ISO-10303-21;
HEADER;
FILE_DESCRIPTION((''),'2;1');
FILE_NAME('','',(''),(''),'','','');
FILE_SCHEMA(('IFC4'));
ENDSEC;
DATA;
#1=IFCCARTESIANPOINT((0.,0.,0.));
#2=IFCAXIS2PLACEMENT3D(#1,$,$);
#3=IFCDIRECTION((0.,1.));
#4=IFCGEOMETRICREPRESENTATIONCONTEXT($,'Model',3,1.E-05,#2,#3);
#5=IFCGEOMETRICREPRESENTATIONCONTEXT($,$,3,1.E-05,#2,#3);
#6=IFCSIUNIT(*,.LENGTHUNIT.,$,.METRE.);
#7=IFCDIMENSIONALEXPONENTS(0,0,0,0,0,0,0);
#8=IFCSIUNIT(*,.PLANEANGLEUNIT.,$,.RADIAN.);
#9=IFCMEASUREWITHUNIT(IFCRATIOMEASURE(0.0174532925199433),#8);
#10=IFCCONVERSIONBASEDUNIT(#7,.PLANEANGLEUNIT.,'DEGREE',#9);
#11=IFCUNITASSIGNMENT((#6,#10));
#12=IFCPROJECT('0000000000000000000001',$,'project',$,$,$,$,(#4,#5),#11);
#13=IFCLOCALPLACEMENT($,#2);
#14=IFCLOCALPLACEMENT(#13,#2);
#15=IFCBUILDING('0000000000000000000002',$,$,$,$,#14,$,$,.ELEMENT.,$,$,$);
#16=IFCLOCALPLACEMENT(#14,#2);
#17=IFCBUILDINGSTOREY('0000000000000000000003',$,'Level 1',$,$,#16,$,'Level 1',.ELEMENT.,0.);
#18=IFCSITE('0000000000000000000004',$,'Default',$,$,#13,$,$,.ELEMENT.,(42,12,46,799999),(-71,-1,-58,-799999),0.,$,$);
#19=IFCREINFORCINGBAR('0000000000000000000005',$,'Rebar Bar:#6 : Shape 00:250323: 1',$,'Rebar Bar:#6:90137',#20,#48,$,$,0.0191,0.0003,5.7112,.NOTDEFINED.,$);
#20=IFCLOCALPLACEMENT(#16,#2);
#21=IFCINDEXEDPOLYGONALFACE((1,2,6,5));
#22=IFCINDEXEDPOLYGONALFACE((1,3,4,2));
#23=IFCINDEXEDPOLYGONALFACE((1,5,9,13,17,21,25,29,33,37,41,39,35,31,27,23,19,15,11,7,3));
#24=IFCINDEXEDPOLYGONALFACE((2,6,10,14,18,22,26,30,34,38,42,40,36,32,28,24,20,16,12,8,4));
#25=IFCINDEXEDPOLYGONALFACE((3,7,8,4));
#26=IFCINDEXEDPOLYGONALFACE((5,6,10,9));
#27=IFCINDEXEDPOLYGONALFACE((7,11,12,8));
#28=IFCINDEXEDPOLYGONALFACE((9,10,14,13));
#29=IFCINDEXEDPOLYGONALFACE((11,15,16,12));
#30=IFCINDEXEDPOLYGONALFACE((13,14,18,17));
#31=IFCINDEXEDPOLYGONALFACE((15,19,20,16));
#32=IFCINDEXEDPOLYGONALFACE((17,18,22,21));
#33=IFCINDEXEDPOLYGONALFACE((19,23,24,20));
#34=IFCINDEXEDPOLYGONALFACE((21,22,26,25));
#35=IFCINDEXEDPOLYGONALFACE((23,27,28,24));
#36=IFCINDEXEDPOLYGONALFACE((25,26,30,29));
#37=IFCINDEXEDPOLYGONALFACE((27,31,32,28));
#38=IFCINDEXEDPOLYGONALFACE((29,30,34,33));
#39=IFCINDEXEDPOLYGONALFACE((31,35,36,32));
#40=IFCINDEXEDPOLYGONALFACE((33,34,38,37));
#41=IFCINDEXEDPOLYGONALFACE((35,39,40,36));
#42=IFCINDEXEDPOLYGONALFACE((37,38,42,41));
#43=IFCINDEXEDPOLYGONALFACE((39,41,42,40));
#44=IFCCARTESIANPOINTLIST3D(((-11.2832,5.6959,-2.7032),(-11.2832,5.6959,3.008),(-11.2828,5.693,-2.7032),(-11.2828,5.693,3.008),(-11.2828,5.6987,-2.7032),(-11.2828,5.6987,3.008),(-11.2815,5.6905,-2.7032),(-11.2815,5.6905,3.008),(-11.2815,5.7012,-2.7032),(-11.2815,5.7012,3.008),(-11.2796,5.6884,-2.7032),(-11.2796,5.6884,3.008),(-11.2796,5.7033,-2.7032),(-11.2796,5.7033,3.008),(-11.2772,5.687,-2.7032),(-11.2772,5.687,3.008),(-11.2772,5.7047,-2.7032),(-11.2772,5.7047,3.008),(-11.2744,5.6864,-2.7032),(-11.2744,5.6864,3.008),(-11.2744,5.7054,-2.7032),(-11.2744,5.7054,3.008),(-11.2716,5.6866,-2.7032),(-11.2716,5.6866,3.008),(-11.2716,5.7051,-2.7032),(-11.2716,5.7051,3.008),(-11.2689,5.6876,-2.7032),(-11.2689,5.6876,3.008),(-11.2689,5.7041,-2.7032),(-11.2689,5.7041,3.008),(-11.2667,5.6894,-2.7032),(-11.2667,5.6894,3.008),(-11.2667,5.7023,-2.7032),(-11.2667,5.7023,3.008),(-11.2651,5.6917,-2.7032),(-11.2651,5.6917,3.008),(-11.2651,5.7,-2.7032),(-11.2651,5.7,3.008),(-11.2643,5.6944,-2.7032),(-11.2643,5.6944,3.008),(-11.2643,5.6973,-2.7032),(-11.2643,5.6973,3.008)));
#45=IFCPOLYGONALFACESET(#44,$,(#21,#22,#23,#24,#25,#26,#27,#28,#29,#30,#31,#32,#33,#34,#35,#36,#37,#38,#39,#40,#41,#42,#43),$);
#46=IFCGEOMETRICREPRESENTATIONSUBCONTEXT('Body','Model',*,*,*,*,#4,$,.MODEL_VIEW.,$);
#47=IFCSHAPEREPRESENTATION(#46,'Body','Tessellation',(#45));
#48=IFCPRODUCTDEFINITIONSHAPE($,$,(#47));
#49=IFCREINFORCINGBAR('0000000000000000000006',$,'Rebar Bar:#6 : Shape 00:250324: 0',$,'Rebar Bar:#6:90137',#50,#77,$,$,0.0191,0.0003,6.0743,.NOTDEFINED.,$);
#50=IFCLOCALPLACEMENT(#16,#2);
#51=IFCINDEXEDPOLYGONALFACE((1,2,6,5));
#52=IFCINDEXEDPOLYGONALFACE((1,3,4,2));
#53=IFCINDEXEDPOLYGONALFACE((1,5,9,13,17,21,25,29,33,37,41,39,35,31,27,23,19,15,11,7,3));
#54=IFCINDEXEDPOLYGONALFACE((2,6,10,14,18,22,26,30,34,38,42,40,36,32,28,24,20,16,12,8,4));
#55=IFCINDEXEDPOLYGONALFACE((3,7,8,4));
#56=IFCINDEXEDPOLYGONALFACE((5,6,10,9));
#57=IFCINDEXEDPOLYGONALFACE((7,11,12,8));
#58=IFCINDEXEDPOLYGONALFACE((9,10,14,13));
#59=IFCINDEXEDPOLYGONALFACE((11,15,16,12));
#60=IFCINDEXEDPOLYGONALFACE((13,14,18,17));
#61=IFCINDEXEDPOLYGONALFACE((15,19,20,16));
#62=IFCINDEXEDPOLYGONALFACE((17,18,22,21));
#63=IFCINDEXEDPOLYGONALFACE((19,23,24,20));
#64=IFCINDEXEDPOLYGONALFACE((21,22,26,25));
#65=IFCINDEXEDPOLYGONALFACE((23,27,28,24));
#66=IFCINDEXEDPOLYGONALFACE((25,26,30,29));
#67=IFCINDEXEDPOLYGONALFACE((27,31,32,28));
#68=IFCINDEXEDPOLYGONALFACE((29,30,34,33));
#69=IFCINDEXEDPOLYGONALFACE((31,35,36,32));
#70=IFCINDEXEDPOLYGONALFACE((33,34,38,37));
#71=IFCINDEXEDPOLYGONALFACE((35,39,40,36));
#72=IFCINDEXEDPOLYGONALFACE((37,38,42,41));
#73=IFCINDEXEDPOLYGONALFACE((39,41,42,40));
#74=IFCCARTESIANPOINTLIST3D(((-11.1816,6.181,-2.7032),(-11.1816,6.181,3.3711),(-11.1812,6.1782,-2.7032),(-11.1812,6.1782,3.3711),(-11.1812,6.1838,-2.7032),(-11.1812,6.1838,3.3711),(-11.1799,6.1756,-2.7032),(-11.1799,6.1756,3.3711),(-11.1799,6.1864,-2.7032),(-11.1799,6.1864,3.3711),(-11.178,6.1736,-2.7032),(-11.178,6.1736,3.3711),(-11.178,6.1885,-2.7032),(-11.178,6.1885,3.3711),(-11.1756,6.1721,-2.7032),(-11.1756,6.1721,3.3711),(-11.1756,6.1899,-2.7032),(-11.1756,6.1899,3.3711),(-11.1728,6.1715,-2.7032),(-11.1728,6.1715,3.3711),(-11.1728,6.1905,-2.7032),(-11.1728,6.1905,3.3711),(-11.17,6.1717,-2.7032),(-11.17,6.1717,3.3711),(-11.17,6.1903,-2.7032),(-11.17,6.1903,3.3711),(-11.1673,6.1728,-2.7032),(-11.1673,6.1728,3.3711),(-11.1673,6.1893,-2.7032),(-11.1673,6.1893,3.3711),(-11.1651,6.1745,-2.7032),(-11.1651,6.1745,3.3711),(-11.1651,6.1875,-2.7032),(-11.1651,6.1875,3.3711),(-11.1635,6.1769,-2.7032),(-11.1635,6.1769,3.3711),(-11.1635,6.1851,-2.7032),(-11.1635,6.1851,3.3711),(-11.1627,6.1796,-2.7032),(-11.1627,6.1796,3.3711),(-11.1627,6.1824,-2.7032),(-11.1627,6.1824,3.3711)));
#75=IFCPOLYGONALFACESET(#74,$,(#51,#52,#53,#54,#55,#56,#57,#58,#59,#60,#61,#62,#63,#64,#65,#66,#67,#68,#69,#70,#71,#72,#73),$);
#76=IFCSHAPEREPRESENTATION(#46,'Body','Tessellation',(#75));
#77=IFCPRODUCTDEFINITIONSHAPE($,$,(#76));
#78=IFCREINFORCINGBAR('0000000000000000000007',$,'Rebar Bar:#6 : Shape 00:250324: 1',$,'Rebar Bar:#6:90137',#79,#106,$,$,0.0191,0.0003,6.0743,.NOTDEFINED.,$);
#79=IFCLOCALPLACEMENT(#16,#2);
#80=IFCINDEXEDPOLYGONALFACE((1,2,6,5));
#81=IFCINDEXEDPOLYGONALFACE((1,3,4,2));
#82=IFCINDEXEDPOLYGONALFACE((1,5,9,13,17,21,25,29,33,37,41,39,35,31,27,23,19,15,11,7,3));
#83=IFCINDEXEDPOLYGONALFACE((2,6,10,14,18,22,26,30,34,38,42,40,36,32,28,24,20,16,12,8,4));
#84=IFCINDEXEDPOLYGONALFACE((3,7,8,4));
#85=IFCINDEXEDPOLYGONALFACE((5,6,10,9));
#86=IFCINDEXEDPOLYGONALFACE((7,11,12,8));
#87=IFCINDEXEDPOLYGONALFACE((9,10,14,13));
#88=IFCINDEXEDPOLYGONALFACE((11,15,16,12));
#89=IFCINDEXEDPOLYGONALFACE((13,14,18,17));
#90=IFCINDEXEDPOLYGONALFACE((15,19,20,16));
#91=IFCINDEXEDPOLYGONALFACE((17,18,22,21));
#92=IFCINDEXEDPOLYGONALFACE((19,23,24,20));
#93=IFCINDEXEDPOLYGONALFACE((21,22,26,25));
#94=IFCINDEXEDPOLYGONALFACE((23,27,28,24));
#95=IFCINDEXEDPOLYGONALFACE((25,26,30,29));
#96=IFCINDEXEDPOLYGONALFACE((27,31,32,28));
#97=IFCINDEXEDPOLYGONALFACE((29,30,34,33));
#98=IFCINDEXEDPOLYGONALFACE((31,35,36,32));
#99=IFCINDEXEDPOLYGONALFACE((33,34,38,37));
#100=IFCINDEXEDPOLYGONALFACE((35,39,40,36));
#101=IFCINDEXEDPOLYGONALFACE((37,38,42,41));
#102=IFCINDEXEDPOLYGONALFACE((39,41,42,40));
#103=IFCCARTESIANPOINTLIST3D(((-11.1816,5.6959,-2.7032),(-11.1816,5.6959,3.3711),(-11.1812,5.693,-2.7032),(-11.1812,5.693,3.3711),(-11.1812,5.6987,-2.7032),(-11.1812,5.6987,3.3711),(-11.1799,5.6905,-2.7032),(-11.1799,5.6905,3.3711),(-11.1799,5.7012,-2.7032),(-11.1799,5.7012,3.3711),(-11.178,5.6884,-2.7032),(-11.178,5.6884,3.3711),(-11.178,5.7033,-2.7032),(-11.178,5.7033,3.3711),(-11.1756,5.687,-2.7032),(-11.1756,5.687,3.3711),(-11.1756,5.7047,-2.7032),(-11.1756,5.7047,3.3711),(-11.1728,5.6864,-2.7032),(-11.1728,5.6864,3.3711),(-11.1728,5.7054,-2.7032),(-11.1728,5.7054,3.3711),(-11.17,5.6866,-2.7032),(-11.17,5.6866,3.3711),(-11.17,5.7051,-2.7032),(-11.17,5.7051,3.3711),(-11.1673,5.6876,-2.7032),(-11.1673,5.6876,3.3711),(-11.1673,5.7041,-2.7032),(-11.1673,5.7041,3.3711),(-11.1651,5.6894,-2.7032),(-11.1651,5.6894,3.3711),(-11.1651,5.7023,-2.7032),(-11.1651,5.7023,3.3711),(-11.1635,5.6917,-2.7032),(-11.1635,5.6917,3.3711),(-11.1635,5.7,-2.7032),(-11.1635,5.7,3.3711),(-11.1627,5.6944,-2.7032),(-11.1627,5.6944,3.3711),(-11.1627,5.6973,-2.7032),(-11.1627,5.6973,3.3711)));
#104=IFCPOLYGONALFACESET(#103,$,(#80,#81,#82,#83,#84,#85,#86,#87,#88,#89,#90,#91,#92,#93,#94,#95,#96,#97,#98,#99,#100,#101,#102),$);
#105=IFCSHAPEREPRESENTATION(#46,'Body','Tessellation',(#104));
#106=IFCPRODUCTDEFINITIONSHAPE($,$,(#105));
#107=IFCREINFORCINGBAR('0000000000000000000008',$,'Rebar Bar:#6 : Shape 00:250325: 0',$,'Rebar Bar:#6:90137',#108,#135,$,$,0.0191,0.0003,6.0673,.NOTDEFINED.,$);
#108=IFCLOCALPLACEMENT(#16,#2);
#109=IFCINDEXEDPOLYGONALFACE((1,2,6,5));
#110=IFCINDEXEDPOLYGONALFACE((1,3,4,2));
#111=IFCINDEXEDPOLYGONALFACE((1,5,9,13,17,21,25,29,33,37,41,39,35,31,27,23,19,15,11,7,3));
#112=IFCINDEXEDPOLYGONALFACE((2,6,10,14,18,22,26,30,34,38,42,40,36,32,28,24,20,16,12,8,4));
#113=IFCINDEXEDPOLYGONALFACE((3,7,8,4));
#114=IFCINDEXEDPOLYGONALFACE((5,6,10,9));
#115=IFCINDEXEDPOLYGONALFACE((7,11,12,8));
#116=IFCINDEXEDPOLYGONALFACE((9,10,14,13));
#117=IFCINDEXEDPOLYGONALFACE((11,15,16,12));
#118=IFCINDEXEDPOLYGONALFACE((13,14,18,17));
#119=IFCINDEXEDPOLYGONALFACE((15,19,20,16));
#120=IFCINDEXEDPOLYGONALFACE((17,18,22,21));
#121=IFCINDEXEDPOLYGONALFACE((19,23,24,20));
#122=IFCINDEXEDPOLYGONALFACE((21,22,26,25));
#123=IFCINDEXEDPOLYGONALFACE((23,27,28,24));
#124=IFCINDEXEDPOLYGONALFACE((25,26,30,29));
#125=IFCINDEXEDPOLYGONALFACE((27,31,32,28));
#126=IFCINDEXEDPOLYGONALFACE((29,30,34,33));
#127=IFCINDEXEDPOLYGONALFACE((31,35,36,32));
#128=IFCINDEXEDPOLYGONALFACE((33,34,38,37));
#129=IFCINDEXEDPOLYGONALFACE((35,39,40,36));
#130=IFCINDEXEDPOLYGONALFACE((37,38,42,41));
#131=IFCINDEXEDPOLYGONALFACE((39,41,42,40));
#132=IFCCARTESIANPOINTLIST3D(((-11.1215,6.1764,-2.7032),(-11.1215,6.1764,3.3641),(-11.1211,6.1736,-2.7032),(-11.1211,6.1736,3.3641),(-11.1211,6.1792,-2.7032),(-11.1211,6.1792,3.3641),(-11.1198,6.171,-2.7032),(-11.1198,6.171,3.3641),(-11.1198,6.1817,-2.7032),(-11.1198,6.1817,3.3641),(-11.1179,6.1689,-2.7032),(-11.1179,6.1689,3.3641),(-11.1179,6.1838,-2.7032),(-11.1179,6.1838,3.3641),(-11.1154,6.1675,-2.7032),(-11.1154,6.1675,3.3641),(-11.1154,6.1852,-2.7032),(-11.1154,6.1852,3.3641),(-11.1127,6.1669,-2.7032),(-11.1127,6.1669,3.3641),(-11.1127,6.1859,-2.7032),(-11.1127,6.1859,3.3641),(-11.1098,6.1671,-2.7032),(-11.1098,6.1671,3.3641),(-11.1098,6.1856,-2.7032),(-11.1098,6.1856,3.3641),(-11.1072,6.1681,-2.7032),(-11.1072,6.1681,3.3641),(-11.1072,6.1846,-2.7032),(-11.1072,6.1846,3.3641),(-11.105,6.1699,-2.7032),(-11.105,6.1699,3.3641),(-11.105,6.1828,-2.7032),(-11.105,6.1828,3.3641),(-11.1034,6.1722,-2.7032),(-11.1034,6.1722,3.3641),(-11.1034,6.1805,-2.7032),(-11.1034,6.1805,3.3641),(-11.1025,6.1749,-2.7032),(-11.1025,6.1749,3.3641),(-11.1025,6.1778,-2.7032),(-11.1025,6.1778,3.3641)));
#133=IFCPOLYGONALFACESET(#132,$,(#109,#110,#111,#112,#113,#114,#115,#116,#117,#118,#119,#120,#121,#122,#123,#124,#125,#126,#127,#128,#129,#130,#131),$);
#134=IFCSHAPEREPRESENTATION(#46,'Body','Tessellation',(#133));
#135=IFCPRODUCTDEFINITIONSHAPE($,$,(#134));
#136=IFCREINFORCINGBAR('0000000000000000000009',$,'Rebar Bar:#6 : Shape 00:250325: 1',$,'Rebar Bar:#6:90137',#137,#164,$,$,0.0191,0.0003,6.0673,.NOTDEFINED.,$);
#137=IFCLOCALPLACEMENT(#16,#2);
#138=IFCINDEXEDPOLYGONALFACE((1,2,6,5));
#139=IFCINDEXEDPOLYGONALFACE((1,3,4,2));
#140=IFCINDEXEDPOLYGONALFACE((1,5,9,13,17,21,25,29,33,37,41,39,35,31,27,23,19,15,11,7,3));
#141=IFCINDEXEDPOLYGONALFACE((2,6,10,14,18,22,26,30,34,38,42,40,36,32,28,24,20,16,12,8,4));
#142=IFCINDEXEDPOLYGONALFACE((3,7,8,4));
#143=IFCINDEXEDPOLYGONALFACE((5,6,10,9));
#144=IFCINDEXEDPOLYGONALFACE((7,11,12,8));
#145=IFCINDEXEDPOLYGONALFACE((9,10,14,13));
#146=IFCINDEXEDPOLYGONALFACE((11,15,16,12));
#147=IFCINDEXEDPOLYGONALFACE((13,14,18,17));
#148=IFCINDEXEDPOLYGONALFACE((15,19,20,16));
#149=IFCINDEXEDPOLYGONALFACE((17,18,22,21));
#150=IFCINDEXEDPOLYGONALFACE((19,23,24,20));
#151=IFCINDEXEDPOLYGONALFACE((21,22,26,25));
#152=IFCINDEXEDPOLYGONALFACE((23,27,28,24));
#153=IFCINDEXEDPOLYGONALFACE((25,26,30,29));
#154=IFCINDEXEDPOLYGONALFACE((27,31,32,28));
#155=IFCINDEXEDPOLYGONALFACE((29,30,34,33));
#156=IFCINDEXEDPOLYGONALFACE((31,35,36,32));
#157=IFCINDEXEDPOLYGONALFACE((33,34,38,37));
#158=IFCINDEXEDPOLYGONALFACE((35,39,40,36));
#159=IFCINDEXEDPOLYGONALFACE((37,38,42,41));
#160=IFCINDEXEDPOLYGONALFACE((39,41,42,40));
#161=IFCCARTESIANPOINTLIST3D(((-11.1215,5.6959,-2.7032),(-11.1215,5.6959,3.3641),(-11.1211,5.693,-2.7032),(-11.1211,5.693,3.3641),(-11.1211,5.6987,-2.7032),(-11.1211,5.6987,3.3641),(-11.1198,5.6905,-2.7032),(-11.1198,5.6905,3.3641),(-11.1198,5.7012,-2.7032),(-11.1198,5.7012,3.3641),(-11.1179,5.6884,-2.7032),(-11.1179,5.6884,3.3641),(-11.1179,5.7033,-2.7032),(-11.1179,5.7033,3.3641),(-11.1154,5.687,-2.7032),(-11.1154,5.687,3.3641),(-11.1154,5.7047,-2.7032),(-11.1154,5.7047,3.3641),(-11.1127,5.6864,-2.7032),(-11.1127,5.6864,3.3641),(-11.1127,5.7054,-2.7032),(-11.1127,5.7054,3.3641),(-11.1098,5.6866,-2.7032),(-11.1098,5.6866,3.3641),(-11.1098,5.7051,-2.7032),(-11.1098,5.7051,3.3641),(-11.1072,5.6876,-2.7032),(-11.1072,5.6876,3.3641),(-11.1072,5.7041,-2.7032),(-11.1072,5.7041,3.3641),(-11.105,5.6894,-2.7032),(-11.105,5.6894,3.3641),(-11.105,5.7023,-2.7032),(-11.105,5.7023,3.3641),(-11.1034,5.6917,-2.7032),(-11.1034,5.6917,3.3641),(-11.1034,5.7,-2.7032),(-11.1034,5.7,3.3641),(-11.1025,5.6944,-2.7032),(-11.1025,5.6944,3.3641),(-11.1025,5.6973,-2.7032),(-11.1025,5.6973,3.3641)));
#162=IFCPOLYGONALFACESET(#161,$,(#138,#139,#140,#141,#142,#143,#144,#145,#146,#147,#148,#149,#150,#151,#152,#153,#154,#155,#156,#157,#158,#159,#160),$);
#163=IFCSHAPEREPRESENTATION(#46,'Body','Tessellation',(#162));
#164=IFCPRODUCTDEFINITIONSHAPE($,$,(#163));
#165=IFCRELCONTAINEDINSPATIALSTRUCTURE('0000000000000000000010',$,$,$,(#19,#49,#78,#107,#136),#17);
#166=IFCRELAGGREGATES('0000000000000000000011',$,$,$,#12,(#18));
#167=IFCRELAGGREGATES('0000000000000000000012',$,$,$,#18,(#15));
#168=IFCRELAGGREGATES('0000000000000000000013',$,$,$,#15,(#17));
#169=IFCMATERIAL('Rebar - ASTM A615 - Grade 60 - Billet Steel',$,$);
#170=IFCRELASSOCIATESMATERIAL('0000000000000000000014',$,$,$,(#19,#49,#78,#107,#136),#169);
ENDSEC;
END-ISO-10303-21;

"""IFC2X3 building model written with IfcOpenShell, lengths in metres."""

from ifc_helpers import new_model, entity, si_unit, converted_unit, direction, origin, place, context, subcontext, project, spatial, material, element, save


model = new_model("IFC2X3")

# Units and contexts
model_context = context("Model", 3, precision=1e-05, world=origin(), true_north=direction((0.0, 1.0)))
context_of_model = context(None, 3, precision=1e-05, world=origin(), true_north=direction((0.0, 1.0)))
body_context = subcontext(model_context, "Body", "Model", "MODEL_VIEW")
ifc_project = project(units=[si_unit("LENGTHUNIT", "METRE"), converted_unit("PLANEANGLEUNIT", "DEGREE", entity("IfcRatioMeasure", 0.0174532925199433), si_unit("PLANEANGLEUNIT", "RADIAN"), dimensions=[0, 0, 0, 0, 0, 0, 0])], contexts=[model_context, context_of_model])

# Site, building, storey
site_placement = place(None, origin())
site = spatial("IfcSite", under=ifc_project, at=site_placement, Name="Default", CompositionType="ELEMENT", RefLatitude=(42, 12, 46, 799999), RefLongitude=(-71, -1, -58, -799999), RefElevation=0.0)
building_placement = place(site_placement, origin())
building = spatial("IfcBuilding", under=site, at=building_placement, CompositionType="ELEMENT")
storey_placement = place(building_placement, origin())
storey = spatial("IfcBuildingStorey", under=building, at=storey_placement, Name="Level 1", LongName="Level 1", CompositionType="ELEMENT", Elevation=0.0)

# Reinforcing bars
ifc_material = material(Name="Rebar - ASTM A615 - Grade 60 - Billet Steel")
reinforcing_bar_1_placement = place(storey_placement, origin())
element("IfcReinforcingBar", 1, at=reinforcing_bar_1_placement, inside=storey, material=ifc_material, Name="Rebar Bar:#6 : Shape 00:250323: 1", ObjectType="Rebar Bar:#6:90137", BarLength=5.7112, BarRole="NOTDEFINED", CrossSectionArea=0.0003, NominalDiameter=0.0191, context=body_context, shape_type="AdvancedSweptSolid", body=[
    entity("IfcSweptDiskSolid", entity("IfcCompositeCurve", [entity("IfcCompositeCurveSegment", "CONTINUOUS", True, entity("IfcPolyline", [entity("IfcCartesianPoint", [-11.2737, 5.6959, 3.008]), entity("IfcCartesianPoint", [-11.2737, 5.6959, -2.7032])]))], False), 0.0095, None, 0.0, 1.0),
])
reinforcing_bar_2_placement = place(storey_placement, origin())
element("IfcReinforcingBar", 2, at=reinforcing_bar_2_placement, inside=storey, material=ifc_material, Name="Rebar Bar:#6 : Shape 00:250324: 0", ObjectType="Rebar Bar:#6:90137", BarLength=6.0743, BarRole="NOTDEFINED", CrossSectionArea=0.0003, NominalDiameter=0.0191, context=body_context, shape_type="AdvancedSweptSolid", body=[
    entity("IfcSweptDiskSolid", entity("IfcCompositeCurve", [entity("IfcCompositeCurveSegment", "CONTINUOUS", True, entity("IfcPolyline", [entity("IfcCartesianPoint", [-11.1721, 6.181, 3.3711]), entity("IfcCartesianPoint", [-11.1721, 6.181, -2.7032])]))], False), 0.0095, None, 0.0, 1.0),
])
reinforcing_bar_3_placement = place(storey_placement, origin())
element("IfcReinforcingBar", 3, at=reinforcing_bar_3_placement, inside=storey, material=ifc_material, Name="Rebar Bar:#6 : Shape 00:250324: 1", ObjectType="Rebar Bar:#6:90137", BarLength=6.0743, BarRole="NOTDEFINED", CrossSectionArea=0.0003, NominalDiameter=0.0191, context=body_context, shape_type="AdvancedSweptSolid", body=[
    entity("IfcSweptDiskSolid", entity("IfcCompositeCurve", [entity("IfcCompositeCurveSegment", "CONTINUOUS", True, entity("IfcPolyline", [entity("IfcCartesianPoint", [-11.1721, 5.6959, 3.3711]), entity("IfcCartesianPoint", [-11.1721, 5.6959, -2.7032])]))], False), 0.0095, None, 0.0, 1.0),
])
reinforcing_bar_4_placement = place(storey_placement, origin())
element("IfcReinforcingBar", 4, at=reinforcing_bar_4_placement, inside=storey, material=ifc_material, Name="Rebar Bar:#6 : Shape 00:250325: 0", ObjectType="Rebar Bar:#6:90137", BarLength=6.0673, BarRole="NOTDEFINED", CrossSectionArea=0.0003, NominalDiameter=0.0191, context=body_context, shape_type="AdvancedSweptSolid", body=[
    entity("IfcSweptDiskSolid", entity("IfcCompositeCurve", [entity("IfcCompositeCurveSegment", "CONTINUOUS", True, entity("IfcPolyline", [entity("IfcCartesianPoint", [-11.112, 6.1764, 3.3641]), entity("IfcCartesianPoint", [-11.112, 6.1764, -2.7032])]))], False), 0.0095, None, 0.0, 1.0),
])
reinforcing_bar_5_placement = place(storey_placement, origin())
element("IfcReinforcingBar", 5, at=reinforcing_bar_5_placement, inside=storey, material=ifc_material, Name="Rebar Bar:#6 : Shape 00:250325: 1", ObjectType="Rebar Bar:#6:90137", BarLength=6.0673, BarRole="NOTDEFINED", CrossSectionArea=0.0003, NominalDiameter=0.0191, context=body_context, shape_type="AdvancedSweptSolid", body=[
    entity("IfcSweptDiskSolid", entity("IfcCompositeCurve", [entity("IfcCompositeCurveSegment", "CONTINUOUS", True, entity("IfcPolyline", [entity("IfcCartesianPoint", [-11.112, 5.6959, 3.3641]), entity("IfcCartesianPoint", [-11.112, 5.6959, -2.7032])]))], False), 0.0095, None, 0.0, 1.0),
])

save(model, "model.ifc")
